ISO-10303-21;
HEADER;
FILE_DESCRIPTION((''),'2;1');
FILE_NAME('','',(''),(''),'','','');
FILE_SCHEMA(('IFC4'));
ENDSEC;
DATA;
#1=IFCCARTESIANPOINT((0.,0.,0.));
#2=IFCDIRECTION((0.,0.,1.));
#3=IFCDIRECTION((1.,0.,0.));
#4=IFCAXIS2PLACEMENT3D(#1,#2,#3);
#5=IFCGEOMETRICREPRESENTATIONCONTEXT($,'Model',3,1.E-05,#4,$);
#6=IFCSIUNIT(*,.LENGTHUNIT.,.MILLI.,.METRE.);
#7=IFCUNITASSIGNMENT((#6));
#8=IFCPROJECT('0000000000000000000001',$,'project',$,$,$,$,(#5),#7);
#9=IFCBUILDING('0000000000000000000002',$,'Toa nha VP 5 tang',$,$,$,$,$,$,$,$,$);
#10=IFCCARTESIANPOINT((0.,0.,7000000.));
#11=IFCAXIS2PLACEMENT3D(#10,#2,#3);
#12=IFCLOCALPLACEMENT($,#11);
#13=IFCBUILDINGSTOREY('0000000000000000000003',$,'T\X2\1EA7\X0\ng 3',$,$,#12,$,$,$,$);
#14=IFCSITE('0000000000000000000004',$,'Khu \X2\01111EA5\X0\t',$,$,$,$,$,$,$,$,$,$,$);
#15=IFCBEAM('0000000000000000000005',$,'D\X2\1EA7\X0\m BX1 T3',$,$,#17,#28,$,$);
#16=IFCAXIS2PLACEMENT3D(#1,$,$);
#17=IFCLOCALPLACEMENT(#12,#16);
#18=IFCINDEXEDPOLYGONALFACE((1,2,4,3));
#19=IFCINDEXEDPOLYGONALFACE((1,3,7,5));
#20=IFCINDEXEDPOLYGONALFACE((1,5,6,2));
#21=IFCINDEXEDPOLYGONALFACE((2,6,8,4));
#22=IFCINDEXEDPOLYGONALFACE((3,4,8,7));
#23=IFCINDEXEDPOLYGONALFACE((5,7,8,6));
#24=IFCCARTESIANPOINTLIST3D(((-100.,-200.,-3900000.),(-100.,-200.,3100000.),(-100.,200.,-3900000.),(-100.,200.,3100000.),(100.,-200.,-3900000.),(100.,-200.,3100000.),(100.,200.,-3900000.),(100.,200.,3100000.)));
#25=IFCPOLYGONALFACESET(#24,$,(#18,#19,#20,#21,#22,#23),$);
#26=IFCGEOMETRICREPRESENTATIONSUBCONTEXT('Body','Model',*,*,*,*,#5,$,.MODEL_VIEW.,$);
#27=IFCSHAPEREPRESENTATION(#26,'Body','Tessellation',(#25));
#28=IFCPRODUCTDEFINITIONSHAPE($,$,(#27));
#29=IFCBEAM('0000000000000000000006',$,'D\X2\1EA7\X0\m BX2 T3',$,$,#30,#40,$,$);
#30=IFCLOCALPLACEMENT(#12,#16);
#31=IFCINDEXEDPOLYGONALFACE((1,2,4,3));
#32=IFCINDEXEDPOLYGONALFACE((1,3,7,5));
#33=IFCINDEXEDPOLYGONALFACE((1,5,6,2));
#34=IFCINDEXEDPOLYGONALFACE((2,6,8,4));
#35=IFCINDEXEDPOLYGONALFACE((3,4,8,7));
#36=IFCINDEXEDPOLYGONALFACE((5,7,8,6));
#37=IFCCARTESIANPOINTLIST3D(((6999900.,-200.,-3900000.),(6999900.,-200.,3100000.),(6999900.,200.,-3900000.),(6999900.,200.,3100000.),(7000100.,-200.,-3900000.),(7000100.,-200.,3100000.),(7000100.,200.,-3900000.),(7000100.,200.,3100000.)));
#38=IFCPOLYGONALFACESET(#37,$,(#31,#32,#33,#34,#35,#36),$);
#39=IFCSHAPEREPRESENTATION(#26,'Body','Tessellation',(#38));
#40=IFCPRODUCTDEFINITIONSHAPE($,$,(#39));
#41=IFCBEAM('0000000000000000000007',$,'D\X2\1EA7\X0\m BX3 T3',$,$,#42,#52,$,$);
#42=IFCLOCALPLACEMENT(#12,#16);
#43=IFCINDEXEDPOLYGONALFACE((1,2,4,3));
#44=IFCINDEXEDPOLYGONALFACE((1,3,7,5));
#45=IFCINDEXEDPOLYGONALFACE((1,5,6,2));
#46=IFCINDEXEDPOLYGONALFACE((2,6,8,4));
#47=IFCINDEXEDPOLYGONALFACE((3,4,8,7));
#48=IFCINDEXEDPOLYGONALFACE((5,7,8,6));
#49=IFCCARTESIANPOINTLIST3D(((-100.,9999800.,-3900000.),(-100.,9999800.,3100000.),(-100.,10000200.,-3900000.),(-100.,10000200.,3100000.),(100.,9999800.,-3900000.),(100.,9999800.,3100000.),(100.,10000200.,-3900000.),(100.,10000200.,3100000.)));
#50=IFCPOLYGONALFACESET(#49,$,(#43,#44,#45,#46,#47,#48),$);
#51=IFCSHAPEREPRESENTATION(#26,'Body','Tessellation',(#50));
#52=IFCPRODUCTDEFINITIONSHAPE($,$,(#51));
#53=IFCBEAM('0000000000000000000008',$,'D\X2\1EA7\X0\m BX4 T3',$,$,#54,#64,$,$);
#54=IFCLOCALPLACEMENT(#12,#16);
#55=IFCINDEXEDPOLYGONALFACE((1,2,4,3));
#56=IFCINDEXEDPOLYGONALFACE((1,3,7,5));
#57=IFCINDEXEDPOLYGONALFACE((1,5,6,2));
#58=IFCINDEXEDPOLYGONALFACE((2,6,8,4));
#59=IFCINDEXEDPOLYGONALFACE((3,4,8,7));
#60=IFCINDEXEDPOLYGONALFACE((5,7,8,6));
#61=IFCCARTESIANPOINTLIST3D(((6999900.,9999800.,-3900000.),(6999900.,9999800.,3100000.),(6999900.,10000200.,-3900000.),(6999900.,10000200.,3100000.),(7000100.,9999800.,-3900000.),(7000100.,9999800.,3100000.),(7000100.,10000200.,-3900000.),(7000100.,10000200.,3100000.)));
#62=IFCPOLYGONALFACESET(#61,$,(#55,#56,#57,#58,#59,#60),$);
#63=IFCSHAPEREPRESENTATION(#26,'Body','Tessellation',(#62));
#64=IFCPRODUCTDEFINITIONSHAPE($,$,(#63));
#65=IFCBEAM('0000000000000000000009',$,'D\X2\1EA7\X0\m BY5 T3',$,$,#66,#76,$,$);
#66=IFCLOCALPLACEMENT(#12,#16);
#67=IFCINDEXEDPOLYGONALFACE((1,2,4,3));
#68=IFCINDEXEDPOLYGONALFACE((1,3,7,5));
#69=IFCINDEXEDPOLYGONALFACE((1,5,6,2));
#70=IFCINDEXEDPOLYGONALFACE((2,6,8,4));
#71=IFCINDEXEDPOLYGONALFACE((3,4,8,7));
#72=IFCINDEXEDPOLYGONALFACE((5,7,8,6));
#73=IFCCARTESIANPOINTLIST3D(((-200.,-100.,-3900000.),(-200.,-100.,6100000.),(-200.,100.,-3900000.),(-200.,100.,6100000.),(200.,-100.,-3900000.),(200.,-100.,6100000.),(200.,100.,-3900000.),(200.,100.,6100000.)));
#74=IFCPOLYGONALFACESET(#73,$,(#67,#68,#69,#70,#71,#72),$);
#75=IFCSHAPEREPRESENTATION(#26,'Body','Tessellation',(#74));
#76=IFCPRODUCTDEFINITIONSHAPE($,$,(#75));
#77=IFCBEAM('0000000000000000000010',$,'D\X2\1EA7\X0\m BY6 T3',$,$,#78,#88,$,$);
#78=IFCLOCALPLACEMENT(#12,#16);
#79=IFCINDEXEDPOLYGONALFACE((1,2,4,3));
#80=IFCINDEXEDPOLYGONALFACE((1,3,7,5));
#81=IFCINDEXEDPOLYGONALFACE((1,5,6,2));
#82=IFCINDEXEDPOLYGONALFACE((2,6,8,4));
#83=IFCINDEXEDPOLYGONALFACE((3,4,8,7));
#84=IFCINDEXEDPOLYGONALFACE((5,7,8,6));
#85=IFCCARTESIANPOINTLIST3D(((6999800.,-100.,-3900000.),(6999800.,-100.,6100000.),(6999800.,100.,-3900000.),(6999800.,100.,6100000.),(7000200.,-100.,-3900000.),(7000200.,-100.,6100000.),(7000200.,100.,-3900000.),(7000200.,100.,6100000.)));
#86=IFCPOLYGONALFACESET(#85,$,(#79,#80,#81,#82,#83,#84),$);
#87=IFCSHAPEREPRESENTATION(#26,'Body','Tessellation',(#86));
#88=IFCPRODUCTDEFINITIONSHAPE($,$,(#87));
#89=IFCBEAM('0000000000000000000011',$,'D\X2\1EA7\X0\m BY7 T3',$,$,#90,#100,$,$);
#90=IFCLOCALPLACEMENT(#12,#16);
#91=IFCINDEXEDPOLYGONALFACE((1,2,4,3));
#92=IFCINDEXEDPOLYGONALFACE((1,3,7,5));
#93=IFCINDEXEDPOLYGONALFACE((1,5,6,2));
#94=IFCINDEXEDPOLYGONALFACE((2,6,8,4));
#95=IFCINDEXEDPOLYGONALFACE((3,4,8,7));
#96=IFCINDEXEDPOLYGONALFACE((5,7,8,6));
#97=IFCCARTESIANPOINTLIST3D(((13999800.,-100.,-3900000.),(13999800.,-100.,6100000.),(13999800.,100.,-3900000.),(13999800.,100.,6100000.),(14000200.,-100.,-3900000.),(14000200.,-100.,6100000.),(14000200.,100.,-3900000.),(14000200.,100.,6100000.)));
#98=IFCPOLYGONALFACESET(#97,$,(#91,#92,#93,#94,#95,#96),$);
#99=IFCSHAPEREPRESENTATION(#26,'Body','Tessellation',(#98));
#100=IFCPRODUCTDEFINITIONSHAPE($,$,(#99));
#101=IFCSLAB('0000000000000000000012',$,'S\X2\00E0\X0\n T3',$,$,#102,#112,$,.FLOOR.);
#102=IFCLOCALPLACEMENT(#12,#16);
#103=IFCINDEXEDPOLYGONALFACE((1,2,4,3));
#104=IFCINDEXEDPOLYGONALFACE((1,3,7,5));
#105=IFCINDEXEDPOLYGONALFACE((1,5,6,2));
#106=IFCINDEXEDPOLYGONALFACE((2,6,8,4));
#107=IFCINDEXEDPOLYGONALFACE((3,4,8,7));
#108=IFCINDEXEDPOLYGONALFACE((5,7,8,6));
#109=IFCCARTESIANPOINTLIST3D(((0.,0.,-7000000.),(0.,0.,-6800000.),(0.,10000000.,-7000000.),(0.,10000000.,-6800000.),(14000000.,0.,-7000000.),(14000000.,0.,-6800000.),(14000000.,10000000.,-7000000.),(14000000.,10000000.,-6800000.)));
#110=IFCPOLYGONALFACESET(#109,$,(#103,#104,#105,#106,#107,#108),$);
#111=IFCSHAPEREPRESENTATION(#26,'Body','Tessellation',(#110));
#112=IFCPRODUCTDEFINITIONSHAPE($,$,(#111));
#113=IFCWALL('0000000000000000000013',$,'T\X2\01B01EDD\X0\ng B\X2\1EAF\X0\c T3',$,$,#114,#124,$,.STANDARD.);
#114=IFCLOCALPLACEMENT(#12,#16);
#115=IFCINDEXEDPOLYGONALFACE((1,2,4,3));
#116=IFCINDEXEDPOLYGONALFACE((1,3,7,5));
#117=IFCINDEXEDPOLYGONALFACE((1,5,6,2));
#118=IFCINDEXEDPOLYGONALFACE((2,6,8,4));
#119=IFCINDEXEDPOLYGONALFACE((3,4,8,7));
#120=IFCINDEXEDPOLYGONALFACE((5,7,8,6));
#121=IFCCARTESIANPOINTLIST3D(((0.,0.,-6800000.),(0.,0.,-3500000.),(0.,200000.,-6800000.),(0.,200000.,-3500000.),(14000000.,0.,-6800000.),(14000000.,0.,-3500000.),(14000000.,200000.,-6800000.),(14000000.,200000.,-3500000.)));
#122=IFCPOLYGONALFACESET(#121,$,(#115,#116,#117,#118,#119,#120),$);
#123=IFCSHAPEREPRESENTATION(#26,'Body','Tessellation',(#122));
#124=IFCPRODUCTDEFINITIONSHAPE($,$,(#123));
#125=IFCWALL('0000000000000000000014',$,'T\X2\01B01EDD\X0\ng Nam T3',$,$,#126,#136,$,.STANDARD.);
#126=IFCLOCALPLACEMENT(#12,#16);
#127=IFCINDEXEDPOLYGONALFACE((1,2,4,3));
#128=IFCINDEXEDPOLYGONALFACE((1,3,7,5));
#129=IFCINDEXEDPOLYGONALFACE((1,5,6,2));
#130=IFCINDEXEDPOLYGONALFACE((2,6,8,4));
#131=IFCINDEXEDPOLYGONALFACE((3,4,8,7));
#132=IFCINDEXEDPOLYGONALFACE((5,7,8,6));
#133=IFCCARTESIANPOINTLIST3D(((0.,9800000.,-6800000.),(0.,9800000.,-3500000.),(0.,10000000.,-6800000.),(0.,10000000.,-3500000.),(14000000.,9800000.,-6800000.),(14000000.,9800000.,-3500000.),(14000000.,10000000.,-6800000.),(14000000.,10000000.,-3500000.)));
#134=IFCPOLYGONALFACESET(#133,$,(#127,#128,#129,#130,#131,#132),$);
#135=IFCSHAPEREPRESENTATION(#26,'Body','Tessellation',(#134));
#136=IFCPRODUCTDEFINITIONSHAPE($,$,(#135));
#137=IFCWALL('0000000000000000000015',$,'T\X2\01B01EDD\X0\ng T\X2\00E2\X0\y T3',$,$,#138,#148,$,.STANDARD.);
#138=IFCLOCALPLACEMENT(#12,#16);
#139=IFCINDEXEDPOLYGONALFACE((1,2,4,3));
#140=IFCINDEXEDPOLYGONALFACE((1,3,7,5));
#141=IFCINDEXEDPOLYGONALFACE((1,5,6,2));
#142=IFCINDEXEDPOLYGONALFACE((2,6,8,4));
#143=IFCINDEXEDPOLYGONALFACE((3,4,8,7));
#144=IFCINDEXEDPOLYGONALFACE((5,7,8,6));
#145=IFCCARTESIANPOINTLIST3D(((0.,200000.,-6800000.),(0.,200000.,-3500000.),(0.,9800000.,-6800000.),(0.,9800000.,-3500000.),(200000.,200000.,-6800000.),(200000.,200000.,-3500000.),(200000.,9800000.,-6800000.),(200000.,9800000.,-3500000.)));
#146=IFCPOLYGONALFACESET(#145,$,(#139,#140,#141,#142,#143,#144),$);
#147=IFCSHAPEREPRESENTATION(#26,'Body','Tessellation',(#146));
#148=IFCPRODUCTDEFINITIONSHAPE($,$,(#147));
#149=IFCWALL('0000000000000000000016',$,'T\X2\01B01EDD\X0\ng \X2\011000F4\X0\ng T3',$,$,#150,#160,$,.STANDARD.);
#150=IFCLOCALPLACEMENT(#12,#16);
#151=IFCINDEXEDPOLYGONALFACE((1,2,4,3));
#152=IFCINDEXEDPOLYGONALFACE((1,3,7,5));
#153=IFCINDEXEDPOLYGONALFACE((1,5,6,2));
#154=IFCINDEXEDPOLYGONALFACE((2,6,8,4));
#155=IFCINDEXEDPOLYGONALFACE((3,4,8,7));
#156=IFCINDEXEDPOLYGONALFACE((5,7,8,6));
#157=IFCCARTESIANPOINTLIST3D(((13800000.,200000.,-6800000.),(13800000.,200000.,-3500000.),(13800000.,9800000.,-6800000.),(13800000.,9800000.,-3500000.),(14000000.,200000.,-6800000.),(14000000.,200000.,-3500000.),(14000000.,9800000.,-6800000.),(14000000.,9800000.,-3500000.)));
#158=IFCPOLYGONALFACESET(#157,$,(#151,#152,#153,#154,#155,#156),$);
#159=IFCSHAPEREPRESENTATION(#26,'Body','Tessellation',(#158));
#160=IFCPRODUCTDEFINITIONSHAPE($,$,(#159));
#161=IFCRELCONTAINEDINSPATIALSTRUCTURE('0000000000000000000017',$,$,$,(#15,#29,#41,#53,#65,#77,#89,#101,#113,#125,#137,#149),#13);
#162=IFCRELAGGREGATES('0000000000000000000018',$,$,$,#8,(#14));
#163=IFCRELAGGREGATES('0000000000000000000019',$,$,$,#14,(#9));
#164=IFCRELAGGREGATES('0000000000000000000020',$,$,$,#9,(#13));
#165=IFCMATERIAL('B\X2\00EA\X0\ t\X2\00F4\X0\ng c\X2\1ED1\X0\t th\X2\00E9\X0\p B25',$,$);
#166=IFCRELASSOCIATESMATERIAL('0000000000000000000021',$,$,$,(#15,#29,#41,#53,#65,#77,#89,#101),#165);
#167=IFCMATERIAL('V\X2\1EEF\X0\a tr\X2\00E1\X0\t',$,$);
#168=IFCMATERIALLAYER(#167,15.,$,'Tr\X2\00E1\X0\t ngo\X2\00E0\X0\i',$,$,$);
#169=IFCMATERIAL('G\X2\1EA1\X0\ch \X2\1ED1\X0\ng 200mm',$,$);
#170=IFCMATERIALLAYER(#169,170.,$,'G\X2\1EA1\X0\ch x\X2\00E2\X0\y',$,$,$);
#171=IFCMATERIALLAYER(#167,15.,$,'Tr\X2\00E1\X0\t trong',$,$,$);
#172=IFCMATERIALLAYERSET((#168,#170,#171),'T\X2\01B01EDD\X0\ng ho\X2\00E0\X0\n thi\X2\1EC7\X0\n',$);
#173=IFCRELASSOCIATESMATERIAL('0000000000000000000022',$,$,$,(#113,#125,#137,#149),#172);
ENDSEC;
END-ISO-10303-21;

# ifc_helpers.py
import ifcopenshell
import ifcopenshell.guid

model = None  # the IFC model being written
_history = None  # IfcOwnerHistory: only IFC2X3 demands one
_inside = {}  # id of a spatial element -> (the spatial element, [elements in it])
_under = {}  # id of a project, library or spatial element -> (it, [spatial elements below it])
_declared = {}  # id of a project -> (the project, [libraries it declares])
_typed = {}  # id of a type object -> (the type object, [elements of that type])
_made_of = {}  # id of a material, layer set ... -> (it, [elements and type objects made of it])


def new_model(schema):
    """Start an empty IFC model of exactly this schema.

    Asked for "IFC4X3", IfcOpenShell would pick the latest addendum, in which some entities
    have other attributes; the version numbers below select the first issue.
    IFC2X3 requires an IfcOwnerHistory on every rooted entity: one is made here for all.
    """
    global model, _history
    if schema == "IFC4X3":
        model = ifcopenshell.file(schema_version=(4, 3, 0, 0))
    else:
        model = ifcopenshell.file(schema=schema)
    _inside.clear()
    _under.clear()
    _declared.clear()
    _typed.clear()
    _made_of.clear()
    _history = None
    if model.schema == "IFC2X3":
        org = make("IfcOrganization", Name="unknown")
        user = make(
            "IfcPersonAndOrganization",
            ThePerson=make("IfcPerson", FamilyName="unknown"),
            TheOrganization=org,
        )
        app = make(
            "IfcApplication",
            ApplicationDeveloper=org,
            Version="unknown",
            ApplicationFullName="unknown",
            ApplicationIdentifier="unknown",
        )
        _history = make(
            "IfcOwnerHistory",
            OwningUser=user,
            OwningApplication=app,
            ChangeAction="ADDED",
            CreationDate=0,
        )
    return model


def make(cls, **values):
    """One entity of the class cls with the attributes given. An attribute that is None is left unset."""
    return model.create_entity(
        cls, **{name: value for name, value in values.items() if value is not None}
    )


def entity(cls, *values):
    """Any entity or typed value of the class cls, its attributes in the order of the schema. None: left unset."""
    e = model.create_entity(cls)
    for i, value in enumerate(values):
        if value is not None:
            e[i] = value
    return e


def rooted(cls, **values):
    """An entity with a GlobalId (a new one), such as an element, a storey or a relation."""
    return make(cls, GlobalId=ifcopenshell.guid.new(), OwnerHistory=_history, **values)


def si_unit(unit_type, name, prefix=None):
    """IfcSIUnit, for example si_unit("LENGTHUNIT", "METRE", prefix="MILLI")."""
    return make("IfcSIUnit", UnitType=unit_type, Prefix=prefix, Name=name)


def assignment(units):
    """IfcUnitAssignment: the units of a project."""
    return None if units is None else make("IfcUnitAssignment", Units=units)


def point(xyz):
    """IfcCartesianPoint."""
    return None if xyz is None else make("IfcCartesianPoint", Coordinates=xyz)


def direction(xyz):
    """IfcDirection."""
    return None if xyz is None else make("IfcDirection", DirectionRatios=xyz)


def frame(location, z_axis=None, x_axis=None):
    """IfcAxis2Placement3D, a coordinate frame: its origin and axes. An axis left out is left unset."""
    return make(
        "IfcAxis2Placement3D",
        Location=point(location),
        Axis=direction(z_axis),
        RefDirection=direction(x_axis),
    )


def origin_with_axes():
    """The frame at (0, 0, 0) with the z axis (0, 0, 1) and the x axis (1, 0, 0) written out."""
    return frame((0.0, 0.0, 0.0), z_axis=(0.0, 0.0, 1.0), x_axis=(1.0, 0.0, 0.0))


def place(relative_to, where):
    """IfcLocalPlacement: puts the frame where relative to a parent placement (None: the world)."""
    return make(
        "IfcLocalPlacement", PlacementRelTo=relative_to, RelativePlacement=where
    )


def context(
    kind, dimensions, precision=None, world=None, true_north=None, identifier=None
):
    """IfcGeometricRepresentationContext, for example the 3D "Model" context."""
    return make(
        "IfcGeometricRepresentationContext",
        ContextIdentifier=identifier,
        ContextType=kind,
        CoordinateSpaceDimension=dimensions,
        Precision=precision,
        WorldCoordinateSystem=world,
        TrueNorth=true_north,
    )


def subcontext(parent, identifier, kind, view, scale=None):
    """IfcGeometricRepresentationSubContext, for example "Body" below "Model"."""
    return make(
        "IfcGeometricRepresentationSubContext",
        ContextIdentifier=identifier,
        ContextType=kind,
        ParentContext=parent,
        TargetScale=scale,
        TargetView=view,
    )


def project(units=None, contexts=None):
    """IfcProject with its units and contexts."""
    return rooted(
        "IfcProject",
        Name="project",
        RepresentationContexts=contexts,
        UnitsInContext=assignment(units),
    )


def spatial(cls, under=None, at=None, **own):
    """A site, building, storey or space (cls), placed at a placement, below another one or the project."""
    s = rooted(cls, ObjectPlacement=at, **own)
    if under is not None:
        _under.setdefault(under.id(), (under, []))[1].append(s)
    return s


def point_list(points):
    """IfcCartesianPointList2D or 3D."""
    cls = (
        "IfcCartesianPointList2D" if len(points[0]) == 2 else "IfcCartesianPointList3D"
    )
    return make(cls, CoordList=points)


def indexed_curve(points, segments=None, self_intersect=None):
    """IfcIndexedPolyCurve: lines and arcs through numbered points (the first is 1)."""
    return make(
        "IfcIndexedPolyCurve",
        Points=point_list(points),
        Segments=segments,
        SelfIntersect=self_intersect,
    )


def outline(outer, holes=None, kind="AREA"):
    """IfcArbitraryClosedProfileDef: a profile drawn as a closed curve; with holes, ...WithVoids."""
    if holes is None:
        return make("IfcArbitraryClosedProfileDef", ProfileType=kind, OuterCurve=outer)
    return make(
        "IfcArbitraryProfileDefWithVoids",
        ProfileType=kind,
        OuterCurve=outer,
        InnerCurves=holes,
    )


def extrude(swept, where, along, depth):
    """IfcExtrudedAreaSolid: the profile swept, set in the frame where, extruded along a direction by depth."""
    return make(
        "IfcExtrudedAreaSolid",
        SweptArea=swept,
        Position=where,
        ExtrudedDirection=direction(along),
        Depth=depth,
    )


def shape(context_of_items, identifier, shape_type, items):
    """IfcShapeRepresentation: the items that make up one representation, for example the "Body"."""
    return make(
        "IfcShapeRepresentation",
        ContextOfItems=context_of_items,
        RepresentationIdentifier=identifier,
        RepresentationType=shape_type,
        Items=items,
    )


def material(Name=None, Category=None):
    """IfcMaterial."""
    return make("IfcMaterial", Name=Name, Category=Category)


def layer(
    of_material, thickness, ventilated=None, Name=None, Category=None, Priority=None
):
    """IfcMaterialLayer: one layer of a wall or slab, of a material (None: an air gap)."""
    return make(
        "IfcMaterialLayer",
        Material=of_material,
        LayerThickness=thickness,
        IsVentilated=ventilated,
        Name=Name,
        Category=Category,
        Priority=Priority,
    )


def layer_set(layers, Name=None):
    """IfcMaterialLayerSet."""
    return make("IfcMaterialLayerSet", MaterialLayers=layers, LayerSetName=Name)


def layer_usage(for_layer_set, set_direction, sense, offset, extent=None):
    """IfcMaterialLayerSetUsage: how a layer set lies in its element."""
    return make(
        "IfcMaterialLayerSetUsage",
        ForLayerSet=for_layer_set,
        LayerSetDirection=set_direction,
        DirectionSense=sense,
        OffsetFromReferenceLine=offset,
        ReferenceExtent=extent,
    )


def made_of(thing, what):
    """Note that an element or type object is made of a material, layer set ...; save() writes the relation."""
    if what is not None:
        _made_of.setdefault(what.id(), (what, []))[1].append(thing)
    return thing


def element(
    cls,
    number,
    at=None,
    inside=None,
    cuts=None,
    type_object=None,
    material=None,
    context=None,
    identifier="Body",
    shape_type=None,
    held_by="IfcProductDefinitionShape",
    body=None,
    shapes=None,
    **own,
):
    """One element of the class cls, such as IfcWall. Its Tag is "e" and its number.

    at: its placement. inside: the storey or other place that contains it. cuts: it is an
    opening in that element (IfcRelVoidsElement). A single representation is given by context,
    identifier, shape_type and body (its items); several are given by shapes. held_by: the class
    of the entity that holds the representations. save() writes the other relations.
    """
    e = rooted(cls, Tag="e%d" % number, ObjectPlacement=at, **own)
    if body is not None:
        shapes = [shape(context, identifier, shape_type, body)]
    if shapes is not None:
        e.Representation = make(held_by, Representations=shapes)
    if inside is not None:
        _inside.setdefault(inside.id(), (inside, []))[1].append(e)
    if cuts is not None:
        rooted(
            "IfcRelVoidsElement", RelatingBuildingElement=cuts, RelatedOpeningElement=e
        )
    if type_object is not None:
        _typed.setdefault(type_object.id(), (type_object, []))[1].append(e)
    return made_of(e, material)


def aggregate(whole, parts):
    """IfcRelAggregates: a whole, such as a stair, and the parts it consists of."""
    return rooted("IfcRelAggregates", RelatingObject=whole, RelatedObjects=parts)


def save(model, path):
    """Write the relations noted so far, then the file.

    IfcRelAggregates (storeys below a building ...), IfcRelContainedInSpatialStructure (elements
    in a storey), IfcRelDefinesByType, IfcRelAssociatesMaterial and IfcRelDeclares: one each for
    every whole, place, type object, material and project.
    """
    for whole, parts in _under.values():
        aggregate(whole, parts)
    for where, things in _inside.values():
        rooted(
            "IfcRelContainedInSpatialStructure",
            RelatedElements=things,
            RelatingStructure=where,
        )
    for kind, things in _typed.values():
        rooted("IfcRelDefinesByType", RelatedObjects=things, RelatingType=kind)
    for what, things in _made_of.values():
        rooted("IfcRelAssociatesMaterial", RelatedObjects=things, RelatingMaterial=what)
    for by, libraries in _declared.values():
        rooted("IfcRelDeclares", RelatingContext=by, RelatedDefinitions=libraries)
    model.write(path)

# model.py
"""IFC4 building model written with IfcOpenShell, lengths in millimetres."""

from ifc_helpers import new_model, entity, si_unit, frame, origin_with_axes, place, context, subcontext, project, spatial, indexed_curve, outline, extrude, material, layer, layer_set, layer_usage, element, save


model = new_model("IFC4")

# Units and contexts
model_context = context("Model", 3, precision=1e-05, world=origin_with_axes())
body_context = subcontext(model_context, "Body", "Model", "MODEL_VIEW")
ifc_project = project(units=[si_unit("LENGTHUNIT", "METRE", prefix="MILLI")], contexts=[model_context])

# Site, building, storey
site = spatial("IfcSite", under=ifc_project, Name="Khu đất")
building = spatial("IfcBuilding", under=site, Name="Toa nha VP 5 tang")
storey_placement = place(None, frame((0.0, 0.0, 7000000.0), z_axis=(0.0, 0.0, 1.0), x_axis=(1.0, 0.0, 0.0)))
storey = spatial("IfcBuildingStorey", under=building, at=storey_placement, Name="Tầng 3")

# Beams
ifc_material_1 = material(Name="Bê tông cốt thép B25")
for number, where, z_axis, x_axis, name in (
    (1, (0.0, 0.0, -3900000.0), (0.0, 0.0, 1.0), (1.0, 0.0, 0.0), "Dầm BX1 T3"),
    (2, (7000000.0, 0.0, -3900000.0), (0.0, 0.0, 1.0), (1.0, 0.0, 0.0), "Dầm BX2 T3"),
    (3, (0.0, 10000000.0, -3900000.0), (0.0, 0.0, 1.0), (1.0, 0.0, 0.0), "Dầm BX3 T3"),
    (4, (7000000.0, 10000000.0, -3900000.0), (0.0, 0.0, 1.0), (1.0, 0.0, 0.0), "Dầm BX4 T3"),
):
    element("IfcBeam", number, at=place(storey_placement, frame(where, z_axis=z_axis, x_axis=x_axis)), inside=storey, material=ifc_material_1, Name=name, context=body_context, shape_type="SweptSolid", body=[
        extrude(entity("IfcRectangleProfileDef", None, None, None, 200.0, 400.0), origin_with_axes(), (0.0, 0.0, 1.0), 7000000.0),
    ])
for number, where, z_axis, x_axis, name in (
    (5, (0.0, 0.0, -3900000.0), (0.0, 0.0, 1.0), (0.0, 1.0, 0.0), "Dầm BY5 T3"),
    (6, (7000000.0, 0.0, -3900000.0), (0.0, 0.0, 1.0), (0.0, 1.0, 0.0), "Dầm BY6 T3"),
    (7, (14000000.0, 0.0, -3900000.0), (0.0, 0.0, 1.0), (0.0, 1.0, 0.0), "Dầm BY7 T3"),
):
    element("IfcBeam", number, at=place(storey_placement, frame(where, z_axis=z_axis, x_axis=x_axis)), inside=storey, material=ifc_material_1, Name=name, context=body_context, shape_type="SweptSolid", body=[
        extrude(entity("IfcRectangleProfileDef", None, None, None, 200.0, 400.0), origin_with_axes(), (0.0, 0.0, 1.0), 10000000.0),
    ])

# Slab
slab_placement = place(storey_placement, frame((0.0, 0.0, -7000000.0), z_axis=(0.0, 0.0, 1.0), x_axis=(1.0, 0.0, 0.0)))
element("IfcSlab", 8, at=slab_placement, inside=storey, material=ifc_material_1, Name="Sàn T3", PredefinedType="FLOOR", context=body_context, shape_type="SweptSolid", body=[
    extrude(outline(indexed_curve([(0.0, 0.0), (14000000.0, 0.0), (14000000.0, 10000000.0), (0.0, 10000000.0), (0.0, 0.0)])), None, (0.0, 0.0, 1.0), 200000.0),
])

# Walls
ifc_material_2 = material(Name="Vữa trát")
ifc_layer_1 = layer(ifc_material_2, 15.0, Name="Trát ngoài")
ifc_material_3 = material(Name="Gạch ống 200mm")
ifc_layer_2 = layer(ifc_material_3, 170.0, Name="Gạch xây")
ifc_layer_3 = layer(ifc_material_2, 15.0, Name="Trát trong")
ifc_layer_set = layer_set([ifc_layer_1, ifc_layer_2, ifc_layer_3], Name="Tường hoàn thiện")
ifc_layer_usage_1 = layer_usage(ifc_layer_set, "AXIS2", "POSITIVE", 0.0)
wall_1_placement = place(storey_placement, frame((0.0, 0.0, -6800000.0), z_axis=(0.0, 0.0, 1.0), x_axis=(1.0, 0.0, 0.0)))
element("IfcWall", 9, at=wall_1_placement, inside=storey, material=ifc_layer_usage_1, Name="Tường Bắc T3", PredefinedType="STANDARD", context=body_context, shape_type="SweptSolid", body=[
    extrude(outline(indexed_curve([(0.0, 0.0), (0.0, 200000.0), (14000000.0, 200000.0), (14000000.0, 0.0), (0.0, 0.0)], self_intersect=False)), origin_with_axes(), (0.0, 0.0, 1.0), 3300000.0),
])
ifc_layer_usage_2 = layer_usage(ifc_layer_set, "AXIS2", "POSITIVE", 0.0)
wall_2_placement = place(storey_placement, frame((0.0, 9800000.0, -6800000.0), z_axis=(0.0, 0.0, 1.0), x_axis=(1.0, 0.0, 0.0)))
element("IfcWall", 10, at=wall_2_placement, inside=storey, material=ifc_layer_usage_2, Name="Tường Nam T3", PredefinedType="STANDARD", context=body_context, shape_type="SweptSolid", body=[
    extrude(outline(indexed_curve([(0.0, 0.0), (0.0, 200000.0), (14000000.0, 200000.0), (14000000.0, 0.0), (0.0, 0.0)], self_intersect=False)), origin_with_axes(), (0.0, 0.0, 1.0), 3300000.0),
])
ifc_layer_usage_3 = layer_usage(ifc_layer_set, "AXIS2", "POSITIVE", 0.0)
wall_3_placement = place(storey_placement, frame((0.0, 200000.0, -6800000.0), z_axis=(0.0, 0.0, 1.0), x_axis=(1.0, 0.0, 0.0)))
element("IfcWall", 11, at=wall_3_placement, inside=storey, material=ifc_layer_usage_3, Name="Tường Tây T3", PredefinedType="STANDARD", context=body_context, shape_type="SweptSolid", body=[
    extrude(outline(indexed_curve([(0.0, 0.0), (0.0, 9600000.0), (200000.0, 9600000.0), (200000.0, 0.0), (0.0, 0.0)], self_intersect=False)), origin_with_axes(), (0.0, 0.0, 1.0), 3300000.0),
])
ifc_layer_usage_4 = layer_usage(ifc_layer_set, "AXIS2", "POSITIVE", 0.0)
wall_4_placement = place(storey_placement, frame((13800000.0, 200000.0, -6800000.0), z_axis=(0.0, 0.0, 1.0), x_axis=(1.0, 0.0, 0.0)))
element("IfcWall", 12, at=wall_4_placement, inside=storey, material=ifc_layer_usage_4, Name="Tường Đông T3", PredefinedType="STANDARD", context=body_context, shape_type="SweptSolid", body=[
    extrude(outline(indexed_curve([(0.0, 0.0), (0.0, 9600000.0), (200000.0, 9600000.0), (200000.0, 0.0), (0.0, 0.0)], self_intersect=False)), origin_with_axes(), (0.0, 0.0, 1.0), 3300000.0),
])

save(model, "model.ifc")
